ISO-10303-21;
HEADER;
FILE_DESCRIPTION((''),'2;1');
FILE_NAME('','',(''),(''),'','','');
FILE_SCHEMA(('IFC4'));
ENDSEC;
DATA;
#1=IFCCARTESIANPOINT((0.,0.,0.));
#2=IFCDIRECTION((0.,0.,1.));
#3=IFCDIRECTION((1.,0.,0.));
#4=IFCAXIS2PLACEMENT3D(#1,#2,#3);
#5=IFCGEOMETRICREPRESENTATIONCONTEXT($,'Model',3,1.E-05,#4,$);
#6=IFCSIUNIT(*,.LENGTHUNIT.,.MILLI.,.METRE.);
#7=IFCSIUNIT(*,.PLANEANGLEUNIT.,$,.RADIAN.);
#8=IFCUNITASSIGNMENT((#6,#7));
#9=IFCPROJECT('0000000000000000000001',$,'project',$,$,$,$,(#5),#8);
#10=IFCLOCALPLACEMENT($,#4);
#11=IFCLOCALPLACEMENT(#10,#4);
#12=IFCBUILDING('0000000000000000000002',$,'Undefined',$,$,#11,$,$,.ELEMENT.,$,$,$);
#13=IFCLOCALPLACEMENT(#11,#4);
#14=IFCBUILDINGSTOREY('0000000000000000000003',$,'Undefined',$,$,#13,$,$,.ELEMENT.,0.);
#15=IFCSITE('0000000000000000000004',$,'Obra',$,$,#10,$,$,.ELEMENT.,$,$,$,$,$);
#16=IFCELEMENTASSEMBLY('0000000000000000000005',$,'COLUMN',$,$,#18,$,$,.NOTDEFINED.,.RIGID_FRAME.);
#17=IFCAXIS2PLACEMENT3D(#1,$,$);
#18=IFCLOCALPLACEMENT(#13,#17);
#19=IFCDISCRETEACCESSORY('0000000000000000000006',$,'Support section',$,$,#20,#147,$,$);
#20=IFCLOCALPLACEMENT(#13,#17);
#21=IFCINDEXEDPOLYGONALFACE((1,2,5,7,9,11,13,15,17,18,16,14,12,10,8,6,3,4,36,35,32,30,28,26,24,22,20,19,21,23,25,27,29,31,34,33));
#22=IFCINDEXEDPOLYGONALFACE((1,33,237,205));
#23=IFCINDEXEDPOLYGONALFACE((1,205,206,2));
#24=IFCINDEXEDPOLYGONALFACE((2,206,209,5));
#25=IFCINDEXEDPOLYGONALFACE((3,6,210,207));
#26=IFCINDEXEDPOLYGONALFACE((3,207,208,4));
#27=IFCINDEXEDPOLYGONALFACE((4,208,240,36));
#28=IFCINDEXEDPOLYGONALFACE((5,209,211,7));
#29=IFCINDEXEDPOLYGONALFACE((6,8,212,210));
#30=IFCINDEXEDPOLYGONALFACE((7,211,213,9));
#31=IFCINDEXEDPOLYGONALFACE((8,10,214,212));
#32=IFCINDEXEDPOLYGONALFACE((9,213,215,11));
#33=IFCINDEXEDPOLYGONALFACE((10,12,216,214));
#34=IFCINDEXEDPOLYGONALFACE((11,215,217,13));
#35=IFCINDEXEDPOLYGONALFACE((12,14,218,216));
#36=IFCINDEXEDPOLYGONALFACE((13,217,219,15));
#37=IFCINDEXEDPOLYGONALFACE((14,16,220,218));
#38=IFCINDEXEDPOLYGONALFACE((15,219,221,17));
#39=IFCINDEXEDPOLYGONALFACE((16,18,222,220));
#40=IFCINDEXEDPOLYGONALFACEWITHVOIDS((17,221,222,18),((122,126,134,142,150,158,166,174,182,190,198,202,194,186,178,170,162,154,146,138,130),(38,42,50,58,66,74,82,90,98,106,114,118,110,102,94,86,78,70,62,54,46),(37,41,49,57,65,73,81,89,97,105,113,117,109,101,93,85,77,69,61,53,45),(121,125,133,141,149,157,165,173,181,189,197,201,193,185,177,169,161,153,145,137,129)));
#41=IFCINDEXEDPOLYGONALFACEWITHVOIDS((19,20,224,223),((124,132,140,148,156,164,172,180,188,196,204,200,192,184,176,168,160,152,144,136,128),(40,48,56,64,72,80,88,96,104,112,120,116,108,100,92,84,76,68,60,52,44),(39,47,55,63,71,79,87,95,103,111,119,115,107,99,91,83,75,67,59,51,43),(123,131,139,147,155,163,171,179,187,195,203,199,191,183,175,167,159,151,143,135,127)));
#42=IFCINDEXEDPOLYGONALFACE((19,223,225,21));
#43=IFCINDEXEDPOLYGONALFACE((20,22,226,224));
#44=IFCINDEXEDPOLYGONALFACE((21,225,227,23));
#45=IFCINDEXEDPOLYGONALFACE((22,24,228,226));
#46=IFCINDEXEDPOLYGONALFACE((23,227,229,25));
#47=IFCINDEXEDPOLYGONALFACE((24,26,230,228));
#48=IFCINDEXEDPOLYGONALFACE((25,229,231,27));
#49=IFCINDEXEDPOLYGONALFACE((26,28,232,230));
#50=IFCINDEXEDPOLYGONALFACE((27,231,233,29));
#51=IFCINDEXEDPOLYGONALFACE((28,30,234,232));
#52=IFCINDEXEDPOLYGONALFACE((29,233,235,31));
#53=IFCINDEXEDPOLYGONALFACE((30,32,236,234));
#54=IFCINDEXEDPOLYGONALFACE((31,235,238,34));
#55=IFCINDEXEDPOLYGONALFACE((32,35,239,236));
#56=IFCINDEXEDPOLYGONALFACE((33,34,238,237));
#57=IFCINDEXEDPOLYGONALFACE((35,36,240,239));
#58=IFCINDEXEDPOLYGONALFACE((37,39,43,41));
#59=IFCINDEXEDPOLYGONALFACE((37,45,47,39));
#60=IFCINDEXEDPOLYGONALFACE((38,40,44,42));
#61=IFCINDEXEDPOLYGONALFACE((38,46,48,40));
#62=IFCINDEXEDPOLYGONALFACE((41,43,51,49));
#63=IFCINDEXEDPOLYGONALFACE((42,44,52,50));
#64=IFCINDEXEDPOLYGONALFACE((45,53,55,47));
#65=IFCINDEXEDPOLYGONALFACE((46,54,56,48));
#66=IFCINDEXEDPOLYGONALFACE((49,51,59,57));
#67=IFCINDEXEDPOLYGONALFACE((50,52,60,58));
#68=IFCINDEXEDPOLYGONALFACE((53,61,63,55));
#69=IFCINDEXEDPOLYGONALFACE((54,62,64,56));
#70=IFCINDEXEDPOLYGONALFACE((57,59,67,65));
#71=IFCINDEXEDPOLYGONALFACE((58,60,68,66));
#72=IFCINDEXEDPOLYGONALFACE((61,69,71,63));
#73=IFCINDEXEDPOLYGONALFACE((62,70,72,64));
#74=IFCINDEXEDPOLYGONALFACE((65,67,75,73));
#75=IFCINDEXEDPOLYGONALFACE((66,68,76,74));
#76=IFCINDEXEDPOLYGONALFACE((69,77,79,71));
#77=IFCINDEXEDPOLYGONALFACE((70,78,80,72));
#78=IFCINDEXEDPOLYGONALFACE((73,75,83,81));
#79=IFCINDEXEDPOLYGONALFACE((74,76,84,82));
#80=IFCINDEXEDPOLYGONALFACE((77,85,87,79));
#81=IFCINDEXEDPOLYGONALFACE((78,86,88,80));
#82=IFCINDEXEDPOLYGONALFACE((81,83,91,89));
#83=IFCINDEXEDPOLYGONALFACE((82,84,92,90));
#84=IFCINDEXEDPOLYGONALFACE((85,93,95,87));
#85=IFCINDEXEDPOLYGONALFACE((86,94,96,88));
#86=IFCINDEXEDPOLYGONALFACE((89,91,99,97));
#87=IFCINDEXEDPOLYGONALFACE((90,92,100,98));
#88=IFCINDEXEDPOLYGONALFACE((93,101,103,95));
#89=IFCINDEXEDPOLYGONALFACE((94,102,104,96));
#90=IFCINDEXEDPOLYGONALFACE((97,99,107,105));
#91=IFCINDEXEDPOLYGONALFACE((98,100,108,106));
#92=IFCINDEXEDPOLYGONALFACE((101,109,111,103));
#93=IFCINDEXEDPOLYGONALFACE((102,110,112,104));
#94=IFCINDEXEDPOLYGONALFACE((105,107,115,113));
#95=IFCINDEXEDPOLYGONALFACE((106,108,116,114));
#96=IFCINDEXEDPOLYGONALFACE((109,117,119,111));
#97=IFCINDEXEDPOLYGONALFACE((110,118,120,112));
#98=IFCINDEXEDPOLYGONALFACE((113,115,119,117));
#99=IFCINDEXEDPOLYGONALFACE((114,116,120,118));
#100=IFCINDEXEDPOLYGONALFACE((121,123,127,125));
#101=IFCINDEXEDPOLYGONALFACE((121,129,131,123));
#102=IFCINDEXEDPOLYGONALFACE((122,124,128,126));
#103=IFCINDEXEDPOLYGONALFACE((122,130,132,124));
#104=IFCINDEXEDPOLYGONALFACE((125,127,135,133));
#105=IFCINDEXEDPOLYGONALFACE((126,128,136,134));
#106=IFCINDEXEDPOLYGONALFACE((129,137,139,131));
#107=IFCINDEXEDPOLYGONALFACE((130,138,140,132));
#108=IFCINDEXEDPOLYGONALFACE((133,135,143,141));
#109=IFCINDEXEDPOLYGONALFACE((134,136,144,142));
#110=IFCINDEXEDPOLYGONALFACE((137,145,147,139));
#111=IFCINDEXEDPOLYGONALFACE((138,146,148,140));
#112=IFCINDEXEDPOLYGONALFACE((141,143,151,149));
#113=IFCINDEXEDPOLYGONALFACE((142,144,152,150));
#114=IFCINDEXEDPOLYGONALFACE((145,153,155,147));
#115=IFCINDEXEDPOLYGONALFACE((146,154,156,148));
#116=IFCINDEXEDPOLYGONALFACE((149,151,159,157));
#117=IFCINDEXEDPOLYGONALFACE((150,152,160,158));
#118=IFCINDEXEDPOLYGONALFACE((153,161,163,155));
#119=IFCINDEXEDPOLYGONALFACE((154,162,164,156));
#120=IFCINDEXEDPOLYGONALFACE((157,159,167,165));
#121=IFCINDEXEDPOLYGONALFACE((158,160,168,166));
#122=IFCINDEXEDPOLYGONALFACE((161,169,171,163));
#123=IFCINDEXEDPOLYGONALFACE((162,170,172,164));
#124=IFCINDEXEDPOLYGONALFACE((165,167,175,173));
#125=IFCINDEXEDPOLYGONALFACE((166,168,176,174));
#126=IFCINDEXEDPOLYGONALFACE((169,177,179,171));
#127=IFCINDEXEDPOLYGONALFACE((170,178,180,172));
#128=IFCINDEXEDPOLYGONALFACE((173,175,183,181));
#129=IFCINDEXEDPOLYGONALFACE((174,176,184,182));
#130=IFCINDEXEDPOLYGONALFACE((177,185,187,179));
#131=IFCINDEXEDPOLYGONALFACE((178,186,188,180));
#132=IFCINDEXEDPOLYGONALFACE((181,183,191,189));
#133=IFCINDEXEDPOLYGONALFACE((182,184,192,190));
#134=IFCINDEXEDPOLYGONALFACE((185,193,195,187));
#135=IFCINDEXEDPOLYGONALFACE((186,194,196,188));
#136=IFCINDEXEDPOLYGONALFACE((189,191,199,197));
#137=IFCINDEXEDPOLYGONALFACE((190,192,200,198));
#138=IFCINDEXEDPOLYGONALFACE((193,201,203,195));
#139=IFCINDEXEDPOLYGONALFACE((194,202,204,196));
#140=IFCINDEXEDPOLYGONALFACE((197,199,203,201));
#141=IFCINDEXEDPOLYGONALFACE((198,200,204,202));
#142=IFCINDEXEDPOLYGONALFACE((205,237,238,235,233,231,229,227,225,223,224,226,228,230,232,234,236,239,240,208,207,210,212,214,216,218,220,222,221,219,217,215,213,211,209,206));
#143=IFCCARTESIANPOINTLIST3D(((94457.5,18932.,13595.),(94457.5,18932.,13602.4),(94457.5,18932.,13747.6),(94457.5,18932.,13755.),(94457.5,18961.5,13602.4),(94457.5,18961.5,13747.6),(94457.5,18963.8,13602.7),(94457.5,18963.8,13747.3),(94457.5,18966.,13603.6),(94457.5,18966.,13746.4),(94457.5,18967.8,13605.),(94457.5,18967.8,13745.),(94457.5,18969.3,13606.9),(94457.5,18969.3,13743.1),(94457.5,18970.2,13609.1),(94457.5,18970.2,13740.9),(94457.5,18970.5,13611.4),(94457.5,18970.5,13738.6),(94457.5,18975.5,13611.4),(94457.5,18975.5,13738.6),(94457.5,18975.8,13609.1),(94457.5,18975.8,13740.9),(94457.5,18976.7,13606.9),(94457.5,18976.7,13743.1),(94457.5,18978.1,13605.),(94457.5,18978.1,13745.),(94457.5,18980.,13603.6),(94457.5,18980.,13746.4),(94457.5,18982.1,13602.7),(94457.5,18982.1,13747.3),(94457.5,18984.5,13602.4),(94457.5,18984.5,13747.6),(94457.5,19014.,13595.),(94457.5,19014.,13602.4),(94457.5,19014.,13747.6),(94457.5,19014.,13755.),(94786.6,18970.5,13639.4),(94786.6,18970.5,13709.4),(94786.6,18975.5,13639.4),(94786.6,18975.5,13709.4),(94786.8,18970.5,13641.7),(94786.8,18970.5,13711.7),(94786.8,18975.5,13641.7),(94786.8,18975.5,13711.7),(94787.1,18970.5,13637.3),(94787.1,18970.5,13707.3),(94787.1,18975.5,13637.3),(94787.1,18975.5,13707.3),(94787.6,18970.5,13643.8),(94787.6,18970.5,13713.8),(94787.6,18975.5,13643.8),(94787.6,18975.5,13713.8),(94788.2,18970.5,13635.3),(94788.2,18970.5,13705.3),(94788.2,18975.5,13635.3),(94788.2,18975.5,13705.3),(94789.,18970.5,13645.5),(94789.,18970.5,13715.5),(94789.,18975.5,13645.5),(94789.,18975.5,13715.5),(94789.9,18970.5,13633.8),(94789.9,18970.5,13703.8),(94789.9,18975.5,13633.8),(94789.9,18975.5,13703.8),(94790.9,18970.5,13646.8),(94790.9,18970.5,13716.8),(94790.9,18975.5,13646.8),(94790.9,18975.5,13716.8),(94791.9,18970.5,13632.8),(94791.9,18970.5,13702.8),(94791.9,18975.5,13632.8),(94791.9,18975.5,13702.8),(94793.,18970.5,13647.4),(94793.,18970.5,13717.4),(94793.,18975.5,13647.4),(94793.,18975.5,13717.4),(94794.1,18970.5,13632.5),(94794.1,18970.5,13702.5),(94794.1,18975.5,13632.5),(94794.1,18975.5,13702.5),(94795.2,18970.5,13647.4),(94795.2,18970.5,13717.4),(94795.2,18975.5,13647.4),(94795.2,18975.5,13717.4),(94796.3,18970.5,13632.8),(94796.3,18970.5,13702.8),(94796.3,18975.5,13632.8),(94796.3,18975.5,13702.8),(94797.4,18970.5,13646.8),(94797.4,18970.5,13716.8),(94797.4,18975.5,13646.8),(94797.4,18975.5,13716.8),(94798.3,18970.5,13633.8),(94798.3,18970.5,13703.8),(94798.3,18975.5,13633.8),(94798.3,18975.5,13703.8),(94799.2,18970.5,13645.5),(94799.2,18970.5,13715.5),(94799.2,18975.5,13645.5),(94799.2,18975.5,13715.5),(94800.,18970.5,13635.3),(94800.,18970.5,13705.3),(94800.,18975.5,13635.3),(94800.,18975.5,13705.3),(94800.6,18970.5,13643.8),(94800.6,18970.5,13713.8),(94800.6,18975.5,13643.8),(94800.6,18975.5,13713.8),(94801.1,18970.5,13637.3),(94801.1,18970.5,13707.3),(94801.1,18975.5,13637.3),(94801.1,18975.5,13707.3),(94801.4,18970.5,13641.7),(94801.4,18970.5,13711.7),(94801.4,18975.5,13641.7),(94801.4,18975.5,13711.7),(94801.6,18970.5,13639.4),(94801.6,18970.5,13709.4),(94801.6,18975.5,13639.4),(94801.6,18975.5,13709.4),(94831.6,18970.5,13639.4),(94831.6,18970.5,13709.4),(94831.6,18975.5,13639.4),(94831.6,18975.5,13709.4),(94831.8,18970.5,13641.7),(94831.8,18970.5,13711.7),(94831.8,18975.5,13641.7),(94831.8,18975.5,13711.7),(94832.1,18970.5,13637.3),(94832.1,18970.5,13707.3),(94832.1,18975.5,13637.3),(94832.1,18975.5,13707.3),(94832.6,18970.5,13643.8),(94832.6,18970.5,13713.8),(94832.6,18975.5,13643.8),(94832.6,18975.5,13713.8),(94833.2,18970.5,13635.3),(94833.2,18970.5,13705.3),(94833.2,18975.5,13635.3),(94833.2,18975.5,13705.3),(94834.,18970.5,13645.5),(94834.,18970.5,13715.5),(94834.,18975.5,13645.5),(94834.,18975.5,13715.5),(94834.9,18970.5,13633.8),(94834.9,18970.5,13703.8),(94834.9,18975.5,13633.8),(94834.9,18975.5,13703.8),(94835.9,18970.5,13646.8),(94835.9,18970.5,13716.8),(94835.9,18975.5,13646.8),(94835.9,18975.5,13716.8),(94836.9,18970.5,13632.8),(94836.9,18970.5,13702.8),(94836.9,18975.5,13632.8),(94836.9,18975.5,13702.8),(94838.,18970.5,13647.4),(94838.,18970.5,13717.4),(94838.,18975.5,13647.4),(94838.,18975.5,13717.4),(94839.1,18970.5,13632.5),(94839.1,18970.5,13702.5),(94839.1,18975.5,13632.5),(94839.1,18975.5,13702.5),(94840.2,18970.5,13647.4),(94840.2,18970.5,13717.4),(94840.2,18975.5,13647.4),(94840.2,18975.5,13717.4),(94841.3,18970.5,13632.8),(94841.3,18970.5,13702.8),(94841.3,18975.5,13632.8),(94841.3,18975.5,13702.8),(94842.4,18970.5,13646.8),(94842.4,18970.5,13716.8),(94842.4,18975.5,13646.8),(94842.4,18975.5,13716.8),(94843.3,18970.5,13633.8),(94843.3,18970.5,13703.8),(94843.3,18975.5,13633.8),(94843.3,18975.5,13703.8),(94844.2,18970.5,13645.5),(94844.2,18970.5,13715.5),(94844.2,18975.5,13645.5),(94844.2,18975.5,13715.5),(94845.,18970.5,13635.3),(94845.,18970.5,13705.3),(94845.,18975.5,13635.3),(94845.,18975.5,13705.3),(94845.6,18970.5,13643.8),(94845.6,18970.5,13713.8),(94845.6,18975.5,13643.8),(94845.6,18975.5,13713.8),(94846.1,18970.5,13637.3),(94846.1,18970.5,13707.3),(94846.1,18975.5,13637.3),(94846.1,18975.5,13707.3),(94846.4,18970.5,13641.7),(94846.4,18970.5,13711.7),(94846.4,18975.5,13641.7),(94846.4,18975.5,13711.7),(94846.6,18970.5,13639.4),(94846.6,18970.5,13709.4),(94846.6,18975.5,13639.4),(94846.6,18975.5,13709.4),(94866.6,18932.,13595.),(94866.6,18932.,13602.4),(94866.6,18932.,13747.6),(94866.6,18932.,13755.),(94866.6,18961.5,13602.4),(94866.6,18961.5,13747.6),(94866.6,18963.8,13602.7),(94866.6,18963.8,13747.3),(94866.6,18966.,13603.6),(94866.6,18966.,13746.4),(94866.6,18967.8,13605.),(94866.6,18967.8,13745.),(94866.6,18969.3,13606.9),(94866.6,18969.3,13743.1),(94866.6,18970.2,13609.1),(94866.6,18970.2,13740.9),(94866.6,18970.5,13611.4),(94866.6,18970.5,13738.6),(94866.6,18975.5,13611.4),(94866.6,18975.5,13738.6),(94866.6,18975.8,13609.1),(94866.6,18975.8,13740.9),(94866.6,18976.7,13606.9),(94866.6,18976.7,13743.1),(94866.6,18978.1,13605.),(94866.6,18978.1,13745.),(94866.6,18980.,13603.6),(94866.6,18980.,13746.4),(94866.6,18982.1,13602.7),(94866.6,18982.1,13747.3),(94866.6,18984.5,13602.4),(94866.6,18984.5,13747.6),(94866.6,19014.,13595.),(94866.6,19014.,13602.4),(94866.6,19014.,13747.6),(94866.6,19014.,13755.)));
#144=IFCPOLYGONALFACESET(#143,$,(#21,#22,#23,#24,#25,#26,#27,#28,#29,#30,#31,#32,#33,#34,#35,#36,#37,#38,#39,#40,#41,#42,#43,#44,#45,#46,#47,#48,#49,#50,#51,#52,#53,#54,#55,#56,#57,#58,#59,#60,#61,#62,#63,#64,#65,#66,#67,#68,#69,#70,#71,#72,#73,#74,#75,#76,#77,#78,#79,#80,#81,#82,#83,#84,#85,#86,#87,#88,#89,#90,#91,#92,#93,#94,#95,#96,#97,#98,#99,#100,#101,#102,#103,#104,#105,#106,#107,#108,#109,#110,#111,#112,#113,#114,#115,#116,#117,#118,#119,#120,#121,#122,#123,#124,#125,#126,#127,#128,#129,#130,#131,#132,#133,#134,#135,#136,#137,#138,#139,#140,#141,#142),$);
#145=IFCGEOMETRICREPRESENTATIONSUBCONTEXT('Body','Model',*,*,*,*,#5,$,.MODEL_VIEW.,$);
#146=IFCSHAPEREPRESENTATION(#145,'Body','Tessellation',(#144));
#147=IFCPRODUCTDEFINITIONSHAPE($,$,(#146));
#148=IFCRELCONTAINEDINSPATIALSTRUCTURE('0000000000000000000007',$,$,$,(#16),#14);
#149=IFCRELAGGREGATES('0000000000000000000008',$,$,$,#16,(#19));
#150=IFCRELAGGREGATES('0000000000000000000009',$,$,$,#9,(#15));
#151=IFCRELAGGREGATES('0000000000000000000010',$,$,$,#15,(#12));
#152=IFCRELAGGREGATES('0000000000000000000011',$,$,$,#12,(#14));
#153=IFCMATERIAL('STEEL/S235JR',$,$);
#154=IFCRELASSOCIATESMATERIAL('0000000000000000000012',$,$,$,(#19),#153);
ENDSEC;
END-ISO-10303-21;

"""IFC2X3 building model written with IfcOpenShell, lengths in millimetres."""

from ifc_helpers import new_model, si_unit, frame, origin_with_axes, origin_2d_with_axis, place, context, subcontext, project, spatial, circle, i_section, extrude, clip, halfspace, source, transform, mapped, material, element, aggregate, save


model = new_model("IFC2X3")

# Units and contexts
model_context = context("Model", 3, precision=1e-05, world=origin_with_axes())
body_context = subcontext(model_context, "Body", "Model", "MODEL_VIEW")
ifc_project = project(units=[si_unit("LENGTHUNIT", "METRE", prefix="MILLI"), si_unit("PLANEANGLEUNIT", "RADIAN")], contexts=[model_context])

# Site, building, storey
site_placement = place(None, origin_with_axes())
site = spatial("IfcSite", under=ifc_project, at=site_placement, Name="Obra", CompositionType="ELEMENT")
building_placement = place(site_placement, origin_with_axes())
building = spatial("IfcBuilding", under=site, at=building_placement, Name="Undefined", CompositionType="ELEMENT")
storey_placement = place(building_placement, origin_with_axes())
storey = spatial("IfcBuildingStorey", under=building, at=storey_placement, Name="Undefined", CompositionType="ELEMENT", Elevation=0.0)

# Element assembly, discrete accessory, opening
assembly_placement = place(storey_placement, origin_with_axes())
assembly = element("IfcElementAssembly", 1, at=assembly_placement, inside=storey, Name="COLUMN", AssemblyPlace="NOTDEFINED", PredefinedType="RIGID_FRAME")
ifc_material_1 = material(Name="STEEL/S235JR")
discrete_accessory_1_placement = place(assembly_placement, frame((94458.3, 18973.0, 13675.0), z_axis=(0.0, 0.0, 1.0), x_axis=(1.0, 0.0, 0.0)))
discrete_accessory_1 = element("IfcDiscreteAccessory", 2, at=discrete_accessory_1_placement, material=ifc_material_1, Name="Support section", context=body_context, shape_type="Clipping", body=[
    clip(clip(extrude(i_section(OverallWidth=82.0, OverallDepth=160.0, WebThickness=5.0, FlangeThickness=7.4, FilletRadius=9.0, at=origin_2d_with_axis()), frame((408.3, 0.0, 0.0), z_axis=(-1.0, 0.0, 0.0), x_axis=(0.0, -1.0, 0.0)), (0.0, 0.0, 1.0), 409.1), halfspace(frame((408.3, 0.0, -180.0), z_axis=(-1.0, 0.0, 0.0), x_axis=(0.0, 1.0, 0.0)), True)), halfspace(frame((-0.8, 0.0, 580.0), z_axis=(-1.0, -0.000033, 0.0), x_axis=(0.000033, -1.0, 0.0)), False)),
])
shared_shape_1 = source(origin_with_axes(), body_context, "Body", "SweptSolid", [
    extrude(circle(Radius=7.5, at=origin_2d_with_axis()), frame((0.0, -2.6, 0.0), z_axis=(0.0, 1.0, 0.0), x_axis=(1.0, 0.0, 0.0)), (0.0, 0.0, 1.0), 5.2),
])
opening_1_placement = place(assembly_placement, frame((94816.6, 18973.0, 13710.0), z_axis=(-1.0, 0.0, 0.0), x_axis=(0.0, 0.0, -1.0)))
element("IfcOpeningElement", 3, at=opening_1_placement, cuts=discrete_accessory_1, ObjectType="Opening", context=body_context, shape_type="MappedRepresentation", body=[
    mapped(shared_shape_1, transform((0.0, 0.0, -22.5))),
    mapped(shared_shape_1, transform((70.0, 0.0, -22.5))),
    mapped(shared_shape_1, transform((0.0, 0.0, 22.5))),
    mapped(shared_shape_1, transform((70.0, 0.0, 22.5))),
])
aggregate(assembly, [discrete_accessory_1])

save(model, "model.ifc")
